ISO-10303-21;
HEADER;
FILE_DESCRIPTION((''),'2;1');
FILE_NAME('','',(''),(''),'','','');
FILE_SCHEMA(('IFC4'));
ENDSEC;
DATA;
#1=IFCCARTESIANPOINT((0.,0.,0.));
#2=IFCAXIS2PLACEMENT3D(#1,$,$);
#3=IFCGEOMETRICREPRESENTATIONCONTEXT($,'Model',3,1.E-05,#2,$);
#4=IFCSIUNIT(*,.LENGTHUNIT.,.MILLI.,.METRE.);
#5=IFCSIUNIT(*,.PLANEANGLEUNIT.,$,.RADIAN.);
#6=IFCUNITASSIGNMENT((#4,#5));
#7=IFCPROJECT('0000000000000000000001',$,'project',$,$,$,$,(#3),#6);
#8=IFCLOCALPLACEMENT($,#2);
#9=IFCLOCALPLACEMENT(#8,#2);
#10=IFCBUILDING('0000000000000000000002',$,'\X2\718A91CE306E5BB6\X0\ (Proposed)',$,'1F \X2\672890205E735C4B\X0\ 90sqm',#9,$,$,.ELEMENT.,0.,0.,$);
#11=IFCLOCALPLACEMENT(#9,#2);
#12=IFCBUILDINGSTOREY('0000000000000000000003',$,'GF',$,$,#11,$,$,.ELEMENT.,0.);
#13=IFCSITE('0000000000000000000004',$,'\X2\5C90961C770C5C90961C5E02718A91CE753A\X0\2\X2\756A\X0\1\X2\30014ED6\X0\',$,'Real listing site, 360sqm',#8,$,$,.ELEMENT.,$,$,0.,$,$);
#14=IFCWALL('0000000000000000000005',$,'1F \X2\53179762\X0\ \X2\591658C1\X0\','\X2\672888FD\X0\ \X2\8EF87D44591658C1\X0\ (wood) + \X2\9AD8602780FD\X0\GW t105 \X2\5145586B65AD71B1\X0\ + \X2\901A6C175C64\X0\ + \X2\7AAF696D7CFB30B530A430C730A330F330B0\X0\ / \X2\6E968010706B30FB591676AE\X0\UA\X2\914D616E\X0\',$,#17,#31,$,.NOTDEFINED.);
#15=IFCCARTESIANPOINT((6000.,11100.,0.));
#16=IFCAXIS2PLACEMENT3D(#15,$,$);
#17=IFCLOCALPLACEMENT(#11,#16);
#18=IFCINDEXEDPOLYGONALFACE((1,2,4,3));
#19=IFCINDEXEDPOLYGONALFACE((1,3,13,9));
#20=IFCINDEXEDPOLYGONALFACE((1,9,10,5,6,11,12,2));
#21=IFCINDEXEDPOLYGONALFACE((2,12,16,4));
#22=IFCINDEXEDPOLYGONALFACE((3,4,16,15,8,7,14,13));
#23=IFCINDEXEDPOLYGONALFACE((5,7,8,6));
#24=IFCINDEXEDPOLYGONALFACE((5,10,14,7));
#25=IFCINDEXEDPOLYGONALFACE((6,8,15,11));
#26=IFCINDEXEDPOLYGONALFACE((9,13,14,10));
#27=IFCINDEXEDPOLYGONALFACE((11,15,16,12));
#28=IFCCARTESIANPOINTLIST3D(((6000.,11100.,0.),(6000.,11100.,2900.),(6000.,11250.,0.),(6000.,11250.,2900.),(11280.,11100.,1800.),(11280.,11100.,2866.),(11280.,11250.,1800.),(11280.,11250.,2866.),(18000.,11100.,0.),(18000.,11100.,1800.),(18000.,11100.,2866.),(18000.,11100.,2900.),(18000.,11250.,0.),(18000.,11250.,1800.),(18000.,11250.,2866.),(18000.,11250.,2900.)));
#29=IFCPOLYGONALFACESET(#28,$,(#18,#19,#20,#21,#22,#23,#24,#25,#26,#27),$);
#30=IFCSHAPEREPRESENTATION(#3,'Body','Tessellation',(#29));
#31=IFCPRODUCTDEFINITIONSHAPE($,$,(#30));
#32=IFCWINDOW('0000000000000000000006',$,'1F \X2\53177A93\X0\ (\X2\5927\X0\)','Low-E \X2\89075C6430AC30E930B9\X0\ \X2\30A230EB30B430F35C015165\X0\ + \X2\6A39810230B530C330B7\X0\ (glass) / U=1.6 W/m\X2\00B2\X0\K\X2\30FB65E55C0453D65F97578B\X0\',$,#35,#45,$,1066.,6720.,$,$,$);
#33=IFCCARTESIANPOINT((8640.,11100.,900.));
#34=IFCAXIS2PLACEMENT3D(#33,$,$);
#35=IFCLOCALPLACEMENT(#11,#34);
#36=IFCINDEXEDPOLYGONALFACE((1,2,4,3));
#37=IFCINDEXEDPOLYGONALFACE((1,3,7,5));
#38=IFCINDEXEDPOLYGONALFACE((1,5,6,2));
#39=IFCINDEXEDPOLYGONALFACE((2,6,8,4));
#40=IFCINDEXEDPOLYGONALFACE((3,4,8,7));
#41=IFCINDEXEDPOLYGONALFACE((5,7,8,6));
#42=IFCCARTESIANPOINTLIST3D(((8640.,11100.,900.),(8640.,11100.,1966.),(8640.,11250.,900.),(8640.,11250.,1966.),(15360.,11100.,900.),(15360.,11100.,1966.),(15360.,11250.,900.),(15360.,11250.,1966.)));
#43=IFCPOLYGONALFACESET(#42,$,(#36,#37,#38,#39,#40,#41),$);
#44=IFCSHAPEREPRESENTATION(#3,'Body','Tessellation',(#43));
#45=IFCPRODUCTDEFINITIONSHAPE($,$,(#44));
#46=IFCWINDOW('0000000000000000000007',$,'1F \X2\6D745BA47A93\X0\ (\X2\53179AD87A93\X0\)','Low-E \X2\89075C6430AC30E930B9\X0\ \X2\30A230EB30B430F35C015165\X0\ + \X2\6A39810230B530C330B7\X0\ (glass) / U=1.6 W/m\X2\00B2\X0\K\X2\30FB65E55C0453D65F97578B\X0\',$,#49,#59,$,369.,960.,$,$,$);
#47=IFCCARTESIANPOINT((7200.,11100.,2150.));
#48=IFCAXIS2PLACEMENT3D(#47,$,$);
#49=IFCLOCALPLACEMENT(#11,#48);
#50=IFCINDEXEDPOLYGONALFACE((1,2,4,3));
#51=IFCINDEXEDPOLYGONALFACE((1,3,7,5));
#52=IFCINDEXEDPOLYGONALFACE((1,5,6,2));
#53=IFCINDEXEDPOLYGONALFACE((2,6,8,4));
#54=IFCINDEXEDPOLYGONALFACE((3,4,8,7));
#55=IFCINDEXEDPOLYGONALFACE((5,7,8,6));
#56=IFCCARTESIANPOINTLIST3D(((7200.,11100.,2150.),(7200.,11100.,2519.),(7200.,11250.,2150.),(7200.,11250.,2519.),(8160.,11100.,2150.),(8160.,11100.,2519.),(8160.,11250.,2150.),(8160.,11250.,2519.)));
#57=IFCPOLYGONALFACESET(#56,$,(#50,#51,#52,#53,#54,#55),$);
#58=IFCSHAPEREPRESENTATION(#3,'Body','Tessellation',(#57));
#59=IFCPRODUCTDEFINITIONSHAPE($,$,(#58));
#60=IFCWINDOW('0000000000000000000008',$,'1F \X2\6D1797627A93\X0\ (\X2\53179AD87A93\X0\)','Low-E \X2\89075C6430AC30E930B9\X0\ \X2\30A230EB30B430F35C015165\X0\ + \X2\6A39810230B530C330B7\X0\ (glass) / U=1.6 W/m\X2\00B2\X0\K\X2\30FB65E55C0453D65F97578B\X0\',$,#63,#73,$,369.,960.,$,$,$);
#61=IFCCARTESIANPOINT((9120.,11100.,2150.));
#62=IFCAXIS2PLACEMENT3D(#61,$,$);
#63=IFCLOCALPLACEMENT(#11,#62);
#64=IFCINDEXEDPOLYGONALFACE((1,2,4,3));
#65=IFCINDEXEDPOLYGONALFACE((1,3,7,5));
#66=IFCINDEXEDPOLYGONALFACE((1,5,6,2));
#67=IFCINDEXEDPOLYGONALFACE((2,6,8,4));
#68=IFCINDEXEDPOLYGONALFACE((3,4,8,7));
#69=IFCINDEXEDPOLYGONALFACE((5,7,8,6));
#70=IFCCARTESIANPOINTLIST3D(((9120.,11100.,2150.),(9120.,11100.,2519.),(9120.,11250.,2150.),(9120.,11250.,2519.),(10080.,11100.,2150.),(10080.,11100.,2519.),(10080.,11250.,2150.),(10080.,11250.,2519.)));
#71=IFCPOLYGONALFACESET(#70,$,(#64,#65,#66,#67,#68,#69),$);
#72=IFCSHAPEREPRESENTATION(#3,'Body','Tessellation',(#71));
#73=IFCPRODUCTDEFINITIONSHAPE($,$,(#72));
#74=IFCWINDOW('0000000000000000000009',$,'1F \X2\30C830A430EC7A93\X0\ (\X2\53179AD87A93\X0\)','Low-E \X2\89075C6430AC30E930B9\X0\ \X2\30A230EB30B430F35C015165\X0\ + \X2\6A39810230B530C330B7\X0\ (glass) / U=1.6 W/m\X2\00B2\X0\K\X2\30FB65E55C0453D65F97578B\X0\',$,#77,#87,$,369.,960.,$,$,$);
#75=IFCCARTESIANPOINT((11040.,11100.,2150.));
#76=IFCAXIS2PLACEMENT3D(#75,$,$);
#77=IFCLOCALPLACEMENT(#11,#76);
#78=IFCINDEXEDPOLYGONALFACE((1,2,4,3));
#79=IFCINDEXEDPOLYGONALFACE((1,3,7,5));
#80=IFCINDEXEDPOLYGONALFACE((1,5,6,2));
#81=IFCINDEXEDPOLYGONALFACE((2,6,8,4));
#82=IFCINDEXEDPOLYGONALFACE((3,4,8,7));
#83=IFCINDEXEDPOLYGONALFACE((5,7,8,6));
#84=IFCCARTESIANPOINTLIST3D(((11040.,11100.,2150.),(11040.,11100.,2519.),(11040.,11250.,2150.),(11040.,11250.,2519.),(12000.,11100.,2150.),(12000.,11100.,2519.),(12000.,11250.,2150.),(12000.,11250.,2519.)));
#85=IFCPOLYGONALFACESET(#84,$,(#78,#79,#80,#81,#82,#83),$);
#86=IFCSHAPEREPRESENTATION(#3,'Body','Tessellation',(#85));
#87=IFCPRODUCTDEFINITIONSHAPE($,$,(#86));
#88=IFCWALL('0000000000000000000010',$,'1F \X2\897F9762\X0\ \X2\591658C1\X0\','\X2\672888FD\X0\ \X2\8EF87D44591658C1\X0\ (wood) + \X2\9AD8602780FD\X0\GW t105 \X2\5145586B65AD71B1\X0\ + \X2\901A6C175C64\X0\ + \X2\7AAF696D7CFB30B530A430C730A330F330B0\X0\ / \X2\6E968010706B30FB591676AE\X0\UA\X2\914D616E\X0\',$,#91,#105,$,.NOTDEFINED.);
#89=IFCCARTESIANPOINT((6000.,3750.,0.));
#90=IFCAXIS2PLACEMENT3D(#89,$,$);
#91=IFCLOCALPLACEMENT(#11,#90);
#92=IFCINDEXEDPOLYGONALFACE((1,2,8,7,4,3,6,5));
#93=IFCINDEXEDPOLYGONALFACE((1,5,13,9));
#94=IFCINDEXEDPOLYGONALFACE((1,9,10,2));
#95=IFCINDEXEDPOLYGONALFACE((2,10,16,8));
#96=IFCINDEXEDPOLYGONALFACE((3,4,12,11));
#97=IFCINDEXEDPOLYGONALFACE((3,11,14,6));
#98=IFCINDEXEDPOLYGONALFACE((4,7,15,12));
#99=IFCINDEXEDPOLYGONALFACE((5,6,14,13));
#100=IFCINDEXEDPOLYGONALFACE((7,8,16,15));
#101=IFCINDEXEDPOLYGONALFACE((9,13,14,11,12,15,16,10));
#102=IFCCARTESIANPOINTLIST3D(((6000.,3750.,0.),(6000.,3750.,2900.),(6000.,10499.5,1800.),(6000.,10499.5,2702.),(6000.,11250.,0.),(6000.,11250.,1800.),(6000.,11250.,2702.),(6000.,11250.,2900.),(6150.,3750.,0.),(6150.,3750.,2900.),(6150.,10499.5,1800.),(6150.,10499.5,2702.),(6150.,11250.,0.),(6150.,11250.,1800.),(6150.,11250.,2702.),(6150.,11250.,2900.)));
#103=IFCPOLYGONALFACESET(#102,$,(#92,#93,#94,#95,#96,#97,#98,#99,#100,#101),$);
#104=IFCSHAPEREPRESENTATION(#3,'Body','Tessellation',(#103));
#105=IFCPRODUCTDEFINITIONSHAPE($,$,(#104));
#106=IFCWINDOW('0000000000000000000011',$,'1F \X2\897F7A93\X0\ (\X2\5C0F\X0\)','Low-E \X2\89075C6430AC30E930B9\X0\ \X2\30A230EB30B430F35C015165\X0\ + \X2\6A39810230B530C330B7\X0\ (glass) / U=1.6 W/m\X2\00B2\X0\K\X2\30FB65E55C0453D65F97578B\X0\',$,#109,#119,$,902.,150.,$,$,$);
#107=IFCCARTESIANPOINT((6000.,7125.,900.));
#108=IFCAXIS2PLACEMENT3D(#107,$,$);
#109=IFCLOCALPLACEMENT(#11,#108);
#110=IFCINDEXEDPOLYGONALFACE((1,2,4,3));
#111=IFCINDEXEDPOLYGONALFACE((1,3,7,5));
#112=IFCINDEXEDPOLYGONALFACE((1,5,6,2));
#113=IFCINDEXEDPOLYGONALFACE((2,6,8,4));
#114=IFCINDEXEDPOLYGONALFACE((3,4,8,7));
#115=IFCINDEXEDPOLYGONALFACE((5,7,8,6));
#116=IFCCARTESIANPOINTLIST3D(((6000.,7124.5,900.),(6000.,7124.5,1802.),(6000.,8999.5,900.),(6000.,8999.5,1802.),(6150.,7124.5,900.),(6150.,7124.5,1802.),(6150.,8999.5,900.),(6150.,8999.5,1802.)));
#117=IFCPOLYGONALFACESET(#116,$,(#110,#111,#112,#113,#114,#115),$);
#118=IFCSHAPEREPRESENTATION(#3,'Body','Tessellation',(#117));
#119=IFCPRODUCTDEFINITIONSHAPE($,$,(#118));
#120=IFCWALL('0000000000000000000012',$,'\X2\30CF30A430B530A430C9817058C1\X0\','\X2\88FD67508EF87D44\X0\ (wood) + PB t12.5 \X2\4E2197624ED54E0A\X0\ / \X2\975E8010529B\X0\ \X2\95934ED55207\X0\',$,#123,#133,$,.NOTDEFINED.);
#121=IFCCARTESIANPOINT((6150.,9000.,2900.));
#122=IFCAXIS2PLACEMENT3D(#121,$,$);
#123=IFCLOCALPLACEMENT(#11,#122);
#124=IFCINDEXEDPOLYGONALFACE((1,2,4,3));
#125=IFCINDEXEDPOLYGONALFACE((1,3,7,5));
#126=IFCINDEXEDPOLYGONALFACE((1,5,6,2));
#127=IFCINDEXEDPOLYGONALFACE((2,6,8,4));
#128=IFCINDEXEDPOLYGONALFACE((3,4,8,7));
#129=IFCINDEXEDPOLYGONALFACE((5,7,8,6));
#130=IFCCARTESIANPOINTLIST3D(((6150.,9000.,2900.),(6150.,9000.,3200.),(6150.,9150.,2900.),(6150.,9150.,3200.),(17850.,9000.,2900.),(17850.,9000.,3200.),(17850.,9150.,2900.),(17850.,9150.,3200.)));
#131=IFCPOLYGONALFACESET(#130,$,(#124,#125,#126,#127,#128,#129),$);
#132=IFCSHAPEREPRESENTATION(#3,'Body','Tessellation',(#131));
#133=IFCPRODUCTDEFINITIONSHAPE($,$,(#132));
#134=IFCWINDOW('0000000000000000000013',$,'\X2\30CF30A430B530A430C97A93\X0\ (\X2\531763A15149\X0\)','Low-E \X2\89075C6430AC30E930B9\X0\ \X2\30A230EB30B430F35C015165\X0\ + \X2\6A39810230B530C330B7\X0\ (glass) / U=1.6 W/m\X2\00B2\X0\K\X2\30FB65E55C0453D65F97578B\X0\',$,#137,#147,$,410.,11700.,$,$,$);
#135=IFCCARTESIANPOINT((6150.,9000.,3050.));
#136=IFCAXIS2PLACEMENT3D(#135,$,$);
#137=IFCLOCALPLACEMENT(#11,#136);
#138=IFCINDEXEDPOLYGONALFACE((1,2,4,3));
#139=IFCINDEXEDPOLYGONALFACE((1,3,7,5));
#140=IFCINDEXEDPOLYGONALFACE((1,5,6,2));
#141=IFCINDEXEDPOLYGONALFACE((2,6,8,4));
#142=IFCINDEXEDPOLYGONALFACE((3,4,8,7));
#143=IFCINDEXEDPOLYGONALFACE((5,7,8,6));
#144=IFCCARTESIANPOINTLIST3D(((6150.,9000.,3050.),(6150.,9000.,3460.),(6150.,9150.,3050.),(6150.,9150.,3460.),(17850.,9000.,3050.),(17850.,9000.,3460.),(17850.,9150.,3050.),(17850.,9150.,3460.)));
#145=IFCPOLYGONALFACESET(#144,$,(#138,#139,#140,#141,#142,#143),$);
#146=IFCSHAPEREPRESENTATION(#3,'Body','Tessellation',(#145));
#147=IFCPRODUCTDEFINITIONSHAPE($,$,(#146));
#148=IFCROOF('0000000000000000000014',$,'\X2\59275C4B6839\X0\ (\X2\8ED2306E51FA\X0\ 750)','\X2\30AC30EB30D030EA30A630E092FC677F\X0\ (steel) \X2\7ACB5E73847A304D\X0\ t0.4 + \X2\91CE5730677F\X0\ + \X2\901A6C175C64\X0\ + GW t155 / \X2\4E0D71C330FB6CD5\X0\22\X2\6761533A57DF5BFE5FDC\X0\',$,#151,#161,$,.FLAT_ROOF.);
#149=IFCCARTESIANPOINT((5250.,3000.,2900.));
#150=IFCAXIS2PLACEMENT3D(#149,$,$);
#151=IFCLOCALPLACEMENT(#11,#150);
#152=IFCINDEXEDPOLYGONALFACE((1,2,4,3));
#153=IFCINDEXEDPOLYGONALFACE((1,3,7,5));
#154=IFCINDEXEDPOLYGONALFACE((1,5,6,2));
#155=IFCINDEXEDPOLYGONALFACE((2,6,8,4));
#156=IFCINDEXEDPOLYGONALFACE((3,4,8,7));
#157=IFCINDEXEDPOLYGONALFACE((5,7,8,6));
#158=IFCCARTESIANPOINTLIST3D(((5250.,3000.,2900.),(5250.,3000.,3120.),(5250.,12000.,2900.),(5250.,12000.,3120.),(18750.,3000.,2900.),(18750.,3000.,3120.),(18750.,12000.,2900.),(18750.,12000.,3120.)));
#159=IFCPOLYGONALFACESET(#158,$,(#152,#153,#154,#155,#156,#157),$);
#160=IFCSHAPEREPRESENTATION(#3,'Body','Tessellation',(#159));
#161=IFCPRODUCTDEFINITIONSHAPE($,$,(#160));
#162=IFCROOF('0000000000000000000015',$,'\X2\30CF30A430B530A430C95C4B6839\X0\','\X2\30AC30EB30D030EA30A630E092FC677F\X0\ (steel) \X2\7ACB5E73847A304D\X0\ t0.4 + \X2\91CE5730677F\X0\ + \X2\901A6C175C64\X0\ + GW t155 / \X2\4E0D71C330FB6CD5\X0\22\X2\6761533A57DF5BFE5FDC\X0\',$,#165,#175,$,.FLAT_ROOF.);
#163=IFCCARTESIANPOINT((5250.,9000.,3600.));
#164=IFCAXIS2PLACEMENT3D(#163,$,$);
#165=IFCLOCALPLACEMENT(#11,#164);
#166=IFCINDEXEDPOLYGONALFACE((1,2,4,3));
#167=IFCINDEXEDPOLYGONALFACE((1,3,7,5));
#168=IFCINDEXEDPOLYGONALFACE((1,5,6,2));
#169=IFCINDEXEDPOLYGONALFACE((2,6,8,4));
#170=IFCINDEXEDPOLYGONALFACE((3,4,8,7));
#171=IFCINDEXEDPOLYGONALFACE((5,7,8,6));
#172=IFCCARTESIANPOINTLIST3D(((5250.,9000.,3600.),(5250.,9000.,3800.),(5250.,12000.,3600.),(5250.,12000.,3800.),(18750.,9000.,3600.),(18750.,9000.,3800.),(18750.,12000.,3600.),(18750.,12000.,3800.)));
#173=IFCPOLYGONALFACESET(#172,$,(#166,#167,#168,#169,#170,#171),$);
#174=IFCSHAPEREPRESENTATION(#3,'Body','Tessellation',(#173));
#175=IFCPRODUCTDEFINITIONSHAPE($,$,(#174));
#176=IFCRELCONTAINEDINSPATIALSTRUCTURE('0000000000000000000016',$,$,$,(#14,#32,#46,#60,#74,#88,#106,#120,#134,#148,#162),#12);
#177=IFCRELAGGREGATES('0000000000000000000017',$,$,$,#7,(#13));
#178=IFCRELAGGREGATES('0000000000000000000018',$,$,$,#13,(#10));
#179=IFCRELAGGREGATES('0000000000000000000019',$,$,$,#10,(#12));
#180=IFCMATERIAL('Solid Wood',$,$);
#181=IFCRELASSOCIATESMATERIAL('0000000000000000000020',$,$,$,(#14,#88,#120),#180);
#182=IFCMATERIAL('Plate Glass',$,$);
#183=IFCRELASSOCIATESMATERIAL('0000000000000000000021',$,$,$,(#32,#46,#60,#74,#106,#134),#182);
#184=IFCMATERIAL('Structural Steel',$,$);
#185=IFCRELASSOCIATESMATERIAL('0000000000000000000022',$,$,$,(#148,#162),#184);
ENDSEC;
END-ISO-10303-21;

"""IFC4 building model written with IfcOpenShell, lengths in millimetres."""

from ifc_helpers import new_model, si_unit, frame, frame_2d, origin, place, context, project, spatial, rectangle, extrude, material, element, fill, save


model = new_model("IFC4")

# Units and contexts
model_context = context("Model", 3, precision=1e-05, world=origin())
ifc_project = project(units=[si_unit("LENGTHUNIT", "METRE", prefix="MILLI"), si_unit("PLANEANGLEUNIT", "RADIAN")], contexts=[model_context])

# Site, building, storey
site_placement = place(None, origin())
site = spatial("IfcSite", under=ifc_project, at=site_placement, Name="岐阜県岐阜市熊野町2番1、他", ObjectType="Real listing site, 360sqm", CompositionType="ELEMENT", RefElevation=0.0)
building_placement = place(site_placement, origin())
building = spatial("IfcBuilding", under=site, at=building_placement, Name="熊野の家 (Proposed)", ObjectType="1F 木造平屋 90sqm", CompositionType="ELEMENT", ElevationOfRefHeight=0.0, ElevationOfTerrain=0.0)
storey_placement = place(building_placement, origin())
storey = spatial("IfcBuildingStorey", under=building, at=storey_placement, Name="GF", CompositionType="ELEMENT", Elevation=0.0)

# Shared definitions
ifc_material_1 = material(Name="Solid Wood")

# Shared definitions
ifc_material_2 = material(Name="Plate Glass")

# Wall, openings, windows
wall_1_placement = place(storey_placement, frame((6000.0, 11100.0, 0.0)))
wall_1 = element("IfcWall", 1, at=wall_1_placement, inside=storey, material=ifc_material_1, Name="1F 北面 外壁", Description="木製 軸組外壁 (wood) + 高性能GW t105 充填断熱 + 通気層 + 窯業系サイディング / 準耐火・外皮UA配慮", PredefinedType="NOTDEFINED", context=model_context, shape_type="SweptSolid", body=[
    extrude(rectangle(XDim=12000.0, YDim=150.0, at=frame_2d((6000.0, 75.0))), frame((6000.0, 11100.0, 0.0)), (0.0, 0.0, 1.0), 2900.0),
])
opening_1_placement = place(storey_placement, frame((8640.0, 11100.0, 900.0)))
opening_1 = element("IfcOpeningElement", 2, at=opening_1_placement, cuts=wall_1, PredefinedType="NOTDEFINED", context=model_context, shape_type="SweptSolid", body=[
    extrude(rectangle(XDim=6720.0, YDim=150.0, at=frame_2d((3360.0, 75.0))), frame((8640.0, 11100.0, 900.0)), (0.0, 0.0, 1.0), 1066.0),
])
opening_2_placement = place(storey_placement, frame((7200.0, 11100.0, 2150.0)))
opening_2 = element("IfcOpeningElement", 3, at=opening_2_placement, cuts=wall_1, PredefinedType="NOTDEFINED", context=model_context, shape_type="SweptSolid", body=[
    extrude(rectangle(XDim=960.0, YDim=150.0, at=frame_2d((480.0, 75.0))), frame((7200.0, 11100.0, 2150.0)), (0.0, 0.0, 1.0), 369.0),
])
opening_3_placement = place(storey_placement, frame((9120.0, 11100.0, 2150.0)))
opening_3 = element("IfcOpeningElement", 4, at=opening_3_placement, cuts=wall_1, PredefinedType="NOTDEFINED", context=model_context, shape_type="SweptSolid", body=[
    extrude(rectangle(XDim=960.0, YDim=150.0, at=frame_2d((480.0, 75.0))), frame((9120.0, 11100.0, 2150.0)), (0.0, 0.0, 1.0), 369.0),
])
opening_4_placement = place(storey_placement, frame((11040.0, 11100.0, 2150.0)))
opening_4 = element("IfcOpeningElement", 5, at=opening_4_placement, cuts=wall_1, PredefinedType="NOTDEFINED", context=model_context, shape_type="SweptSolid", body=[
    extrude(rectangle(XDim=960.0, YDim=150.0, at=frame_2d((480.0, 75.0))), frame((11040.0, 11100.0, 2150.0)), (0.0, 0.0, 1.0), 369.0),
])
window_1_placement = place(storey_placement, frame((8640.0, 11100.0, 900.0)))
window_1 = element("IfcWindow", 6, at=window_1_placement, inside=storey, material=ifc_material_2, Name="1F 北窓 (大)", Description="Low-E 複層ガラス アルゴン封入 + 樹脂サッシ (glass) / U=1.6 W/m²K・日射取得型", OverallHeight=1066.0, OverallWidth=6720.0, context=model_context, shape_type="SweptSolid", body=[
    extrude(rectangle(XDim=6720.0, YDim=150.0, at=frame_2d((3360.0, 75.0))), frame((8640.0, 11100.0, 900.0)), (0.0, 0.0, 1.0), 1066.0),
])
fill(opening_1, window_1)
window_2_placement = place(storey_placement, frame((7200.0, 11100.0, 2150.0)))
window_2 = element("IfcWindow", 7, at=window_2_placement, inside=storey, material=ifc_material_2, Name="1F 浴室窓 (北高窓)", Description="Low-E 複層ガラス アルゴン封入 + 樹脂サッシ (glass) / U=1.6 W/m²K・日射取得型", OverallHeight=369.0, OverallWidth=960.0, context=model_context, shape_type="SweptSolid", body=[
    extrude(rectangle(XDim=960.0, YDim=150.0, at=frame_2d((480.0, 75.0))), frame((7200.0, 11100.0, 2150.0)), (0.0, 0.0, 1.0), 369.0),
])
fill(opening_2, window_2)
window_3_placement = place(storey_placement, frame((9120.0, 11100.0, 2150.0)))
window_3 = element("IfcWindow", 8, at=window_3_placement, inside=storey, material=ifc_material_2, Name="1F 洗面窓 (北高窓)", Description="Low-E 複層ガラス アルゴン封入 + 樹脂サッシ (glass) / U=1.6 W/m²K・日射取得型", OverallHeight=369.0, OverallWidth=960.0, context=model_context, shape_type="SweptSolid", body=[
    extrude(rectangle(XDim=960.0, YDim=150.0, at=frame_2d((480.0, 75.0))), frame((9120.0, 11100.0, 2150.0)), (0.0, 0.0, 1.0), 369.0),
])
fill(opening_3, window_3)
window_4_placement = place(storey_placement, frame((11040.0, 11100.0, 2150.0)))
window_4 = element("IfcWindow", 9, at=window_4_placement, inside=storey, material=ifc_material_2, Name="1F トイレ窓 (北高窓)", Description="Low-E 複層ガラス アルゴン封入 + 樹脂サッシ (glass) / U=1.6 W/m²K・日射取得型", OverallHeight=369.0, OverallWidth=960.0, context=model_context, shape_type="SweptSolid", body=[
    extrude(rectangle(XDim=960.0, YDim=150.0, at=frame_2d((480.0, 75.0))), frame((11040.0, 11100.0, 2150.0)), (0.0, 0.0, 1.0), 369.0),
])
fill(opening_4, window_4)

# Wall, opening, window
wall_2_placement = place(storey_placement, frame((6000.0, 3750.0, 0.0)))
wall_2 = element("IfcWall", 10, at=wall_2_placement, inside=storey, material=ifc_material_1, Name="1F 西面 外壁", Description="木製 軸組外壁 (wood) + 高性能GW t105 充填断熱 + 通気層 + 窯業系サイディング / 準耐火・外皮UA配慮", PredefinedType="NOTDEFINED", context=model_context, shape_type="SweptSolid", body=[
    extrude(rectangle(XDim=150.0, YDim=7500.0, at=frame_2d((75.0, 3750.0))), frame((6000.0, 3750.0, 0.0)), (0.0, 0.0, 1.0), 2900.0),
])
opening_5_placement = place(storey_placement, frame((6000.0, 7125.0, 900.0)))
opening_5 = element("IfcOpeningElement", 11, at=opening_5_placement, cuts=wall_2, PredefinedType="NOTDEFINED", context=model_context, shape_type="SweptSolid", body=[
    extrude(rectangle(XDim=150.0, YDim=1875.0, at=frame_2d((75.0, 937.0))), frame((6000.0, 7125.0, 900.0)), (0.0, 0.0, 1.0), 902.0),
])
window_5_placement = place(storey_placement, frame((6000.0, 7125.0, 900.0)))
window_5 = element("IfcWindow", 12, at=window_5_placement, inside=storey, material=ifc_material_2, Name="1F 西窓 (小)", Description="Low-E 複層ガラス アルゴン封入 + 樹脂サッシ (glass) / U=1.6 W/m²K・日射取得型", OverallHeight=902.0, OverallWidth=150.0, context=model_context, shape_type="SweptSolid", body=[
    extrude(rectangle(XDim=150.0, YDim=1875.0, at=frame_2d((75.0, 937.0))), frame((6000.0, 7125.0, 900.0)), (0.0, 0.0, 1.0), 902.0),
])
fill(opening_5, window_5)

# Wall, opening, window
wall_3_placement = place(storey_placement, frame((6150.0, 9000.0, 2900.0)))
wall_3 = element("IfcWall", 13, at=wall_3_placement, inside=storey, material=ifc_material_1, Name="ハイサイド腰壁", Description="製材軸組 (wood) + PB t12.5 両面仕上 / 非耐力 間仕切", PredefinedType="NOTDEFINED", context=model_context, shape_type="SweptSolid", body=[
    extrude(rectangle(XDim=11700.0, YDim=150.0, at=frame_2d((5850.0, 75.0))), frame((6150.0, 9000.0, 2900.0)), (0.0, 0.0, 1.0), 700.0),
])
opening_6_placement = place(storey_placement, frame((6150.0, 9000.0, 3050.0)))
opening_6 = element("IfcOpeningElement", 14, at=opening_6_placement, cuts=wall_3, PredefinedType="NOTDEFINED", context=model_context, shape_type="SweptSolid", body=[
    extrude(rectangle(XDim=11700.0, YDim=150.0, at=frame_2d((5850.0, 75.0))), frame((6150.0, 9000.0, 3050.0)), (0.0, 0.0, 1.0), 410.0),
])
window_6_placement = place(storey_placement, frame((6150.0, 9000.0, 3050.0)))
window_6 = element("IfcWindow", 15, at=window_6_placement, inside=storey, material=ifc_material_2, Name="ハイサイド窓 (北採光)", Description="Low-E 複層ガラス アルゴン封入 + 樹脂サッシ (glass) / U=1.6 W/m²K・日射取得型", OverallHeight=410.0, OverallWidth=11700.0, context=model_context, shape_type="SweptSolid", body=[
    extrude(rectangle(XDim=11700.0, YDim=150.0, at=frame_2d((5850.0, 75.0))), frame((6150.0, 9000.0, 3050.0)), (0.0, 0.0, 1.0), 410.0),
])
fill(opening_6, window_6)

# Roofs
ifc_material_3 = material(Name="Structural Steel")
roof_1_placement = place(storey_placement, frame((5250.0, 3000.0, 2900.0)))
element("IfcRoof", 16, at=roof_1_placement, inside=storey, material=ifc_material_3, Name="大屋根 (軒の出 750)", Description="ガルバリウム鋼板 (steel) 立平葺き t0.4 + 野地板 + 通気層 + GW t155 / 不燃・法22条区域対応", PredefinedType="FLAT_ROOF", context=model_context, shape_type="SweptSolid", body=[
    extrude(rectangle(XDim=13500.0, YDim=9000.0, at=frame_2d((6750.0, 4500.0))), frame((5250.0, 3000.0, 2900.0)), (0.0, 0.0, 1.0), 220.0),
])
roof_2_placement = place(storey_placement, frame((5250.0, 9000.0, 3600.0)))
element("IfcRoof", 17, at=roof_2_placement, inside=storey, material=ifc_material_3, Name="ハイサイド屋根", Description="ガルバリウム鋼板 (steel) 立平葺き t0.4 + 野地板 + 通気層 + GW t155 / 不燃・法22条区域対応", PredefinedType="FLAT_ROOF", context=model_context, shape_type="SweptSolid", body=[
    extrude(rectangle(XDim=13500.0, YDim=3000.0, at=frame_2d((6750.0, 1500.0))), frame((5250.0, 9000.0, 3600.0)), (0.0, 0.0, 1.0), 200.0),
])

save(model, "model.ifc")
